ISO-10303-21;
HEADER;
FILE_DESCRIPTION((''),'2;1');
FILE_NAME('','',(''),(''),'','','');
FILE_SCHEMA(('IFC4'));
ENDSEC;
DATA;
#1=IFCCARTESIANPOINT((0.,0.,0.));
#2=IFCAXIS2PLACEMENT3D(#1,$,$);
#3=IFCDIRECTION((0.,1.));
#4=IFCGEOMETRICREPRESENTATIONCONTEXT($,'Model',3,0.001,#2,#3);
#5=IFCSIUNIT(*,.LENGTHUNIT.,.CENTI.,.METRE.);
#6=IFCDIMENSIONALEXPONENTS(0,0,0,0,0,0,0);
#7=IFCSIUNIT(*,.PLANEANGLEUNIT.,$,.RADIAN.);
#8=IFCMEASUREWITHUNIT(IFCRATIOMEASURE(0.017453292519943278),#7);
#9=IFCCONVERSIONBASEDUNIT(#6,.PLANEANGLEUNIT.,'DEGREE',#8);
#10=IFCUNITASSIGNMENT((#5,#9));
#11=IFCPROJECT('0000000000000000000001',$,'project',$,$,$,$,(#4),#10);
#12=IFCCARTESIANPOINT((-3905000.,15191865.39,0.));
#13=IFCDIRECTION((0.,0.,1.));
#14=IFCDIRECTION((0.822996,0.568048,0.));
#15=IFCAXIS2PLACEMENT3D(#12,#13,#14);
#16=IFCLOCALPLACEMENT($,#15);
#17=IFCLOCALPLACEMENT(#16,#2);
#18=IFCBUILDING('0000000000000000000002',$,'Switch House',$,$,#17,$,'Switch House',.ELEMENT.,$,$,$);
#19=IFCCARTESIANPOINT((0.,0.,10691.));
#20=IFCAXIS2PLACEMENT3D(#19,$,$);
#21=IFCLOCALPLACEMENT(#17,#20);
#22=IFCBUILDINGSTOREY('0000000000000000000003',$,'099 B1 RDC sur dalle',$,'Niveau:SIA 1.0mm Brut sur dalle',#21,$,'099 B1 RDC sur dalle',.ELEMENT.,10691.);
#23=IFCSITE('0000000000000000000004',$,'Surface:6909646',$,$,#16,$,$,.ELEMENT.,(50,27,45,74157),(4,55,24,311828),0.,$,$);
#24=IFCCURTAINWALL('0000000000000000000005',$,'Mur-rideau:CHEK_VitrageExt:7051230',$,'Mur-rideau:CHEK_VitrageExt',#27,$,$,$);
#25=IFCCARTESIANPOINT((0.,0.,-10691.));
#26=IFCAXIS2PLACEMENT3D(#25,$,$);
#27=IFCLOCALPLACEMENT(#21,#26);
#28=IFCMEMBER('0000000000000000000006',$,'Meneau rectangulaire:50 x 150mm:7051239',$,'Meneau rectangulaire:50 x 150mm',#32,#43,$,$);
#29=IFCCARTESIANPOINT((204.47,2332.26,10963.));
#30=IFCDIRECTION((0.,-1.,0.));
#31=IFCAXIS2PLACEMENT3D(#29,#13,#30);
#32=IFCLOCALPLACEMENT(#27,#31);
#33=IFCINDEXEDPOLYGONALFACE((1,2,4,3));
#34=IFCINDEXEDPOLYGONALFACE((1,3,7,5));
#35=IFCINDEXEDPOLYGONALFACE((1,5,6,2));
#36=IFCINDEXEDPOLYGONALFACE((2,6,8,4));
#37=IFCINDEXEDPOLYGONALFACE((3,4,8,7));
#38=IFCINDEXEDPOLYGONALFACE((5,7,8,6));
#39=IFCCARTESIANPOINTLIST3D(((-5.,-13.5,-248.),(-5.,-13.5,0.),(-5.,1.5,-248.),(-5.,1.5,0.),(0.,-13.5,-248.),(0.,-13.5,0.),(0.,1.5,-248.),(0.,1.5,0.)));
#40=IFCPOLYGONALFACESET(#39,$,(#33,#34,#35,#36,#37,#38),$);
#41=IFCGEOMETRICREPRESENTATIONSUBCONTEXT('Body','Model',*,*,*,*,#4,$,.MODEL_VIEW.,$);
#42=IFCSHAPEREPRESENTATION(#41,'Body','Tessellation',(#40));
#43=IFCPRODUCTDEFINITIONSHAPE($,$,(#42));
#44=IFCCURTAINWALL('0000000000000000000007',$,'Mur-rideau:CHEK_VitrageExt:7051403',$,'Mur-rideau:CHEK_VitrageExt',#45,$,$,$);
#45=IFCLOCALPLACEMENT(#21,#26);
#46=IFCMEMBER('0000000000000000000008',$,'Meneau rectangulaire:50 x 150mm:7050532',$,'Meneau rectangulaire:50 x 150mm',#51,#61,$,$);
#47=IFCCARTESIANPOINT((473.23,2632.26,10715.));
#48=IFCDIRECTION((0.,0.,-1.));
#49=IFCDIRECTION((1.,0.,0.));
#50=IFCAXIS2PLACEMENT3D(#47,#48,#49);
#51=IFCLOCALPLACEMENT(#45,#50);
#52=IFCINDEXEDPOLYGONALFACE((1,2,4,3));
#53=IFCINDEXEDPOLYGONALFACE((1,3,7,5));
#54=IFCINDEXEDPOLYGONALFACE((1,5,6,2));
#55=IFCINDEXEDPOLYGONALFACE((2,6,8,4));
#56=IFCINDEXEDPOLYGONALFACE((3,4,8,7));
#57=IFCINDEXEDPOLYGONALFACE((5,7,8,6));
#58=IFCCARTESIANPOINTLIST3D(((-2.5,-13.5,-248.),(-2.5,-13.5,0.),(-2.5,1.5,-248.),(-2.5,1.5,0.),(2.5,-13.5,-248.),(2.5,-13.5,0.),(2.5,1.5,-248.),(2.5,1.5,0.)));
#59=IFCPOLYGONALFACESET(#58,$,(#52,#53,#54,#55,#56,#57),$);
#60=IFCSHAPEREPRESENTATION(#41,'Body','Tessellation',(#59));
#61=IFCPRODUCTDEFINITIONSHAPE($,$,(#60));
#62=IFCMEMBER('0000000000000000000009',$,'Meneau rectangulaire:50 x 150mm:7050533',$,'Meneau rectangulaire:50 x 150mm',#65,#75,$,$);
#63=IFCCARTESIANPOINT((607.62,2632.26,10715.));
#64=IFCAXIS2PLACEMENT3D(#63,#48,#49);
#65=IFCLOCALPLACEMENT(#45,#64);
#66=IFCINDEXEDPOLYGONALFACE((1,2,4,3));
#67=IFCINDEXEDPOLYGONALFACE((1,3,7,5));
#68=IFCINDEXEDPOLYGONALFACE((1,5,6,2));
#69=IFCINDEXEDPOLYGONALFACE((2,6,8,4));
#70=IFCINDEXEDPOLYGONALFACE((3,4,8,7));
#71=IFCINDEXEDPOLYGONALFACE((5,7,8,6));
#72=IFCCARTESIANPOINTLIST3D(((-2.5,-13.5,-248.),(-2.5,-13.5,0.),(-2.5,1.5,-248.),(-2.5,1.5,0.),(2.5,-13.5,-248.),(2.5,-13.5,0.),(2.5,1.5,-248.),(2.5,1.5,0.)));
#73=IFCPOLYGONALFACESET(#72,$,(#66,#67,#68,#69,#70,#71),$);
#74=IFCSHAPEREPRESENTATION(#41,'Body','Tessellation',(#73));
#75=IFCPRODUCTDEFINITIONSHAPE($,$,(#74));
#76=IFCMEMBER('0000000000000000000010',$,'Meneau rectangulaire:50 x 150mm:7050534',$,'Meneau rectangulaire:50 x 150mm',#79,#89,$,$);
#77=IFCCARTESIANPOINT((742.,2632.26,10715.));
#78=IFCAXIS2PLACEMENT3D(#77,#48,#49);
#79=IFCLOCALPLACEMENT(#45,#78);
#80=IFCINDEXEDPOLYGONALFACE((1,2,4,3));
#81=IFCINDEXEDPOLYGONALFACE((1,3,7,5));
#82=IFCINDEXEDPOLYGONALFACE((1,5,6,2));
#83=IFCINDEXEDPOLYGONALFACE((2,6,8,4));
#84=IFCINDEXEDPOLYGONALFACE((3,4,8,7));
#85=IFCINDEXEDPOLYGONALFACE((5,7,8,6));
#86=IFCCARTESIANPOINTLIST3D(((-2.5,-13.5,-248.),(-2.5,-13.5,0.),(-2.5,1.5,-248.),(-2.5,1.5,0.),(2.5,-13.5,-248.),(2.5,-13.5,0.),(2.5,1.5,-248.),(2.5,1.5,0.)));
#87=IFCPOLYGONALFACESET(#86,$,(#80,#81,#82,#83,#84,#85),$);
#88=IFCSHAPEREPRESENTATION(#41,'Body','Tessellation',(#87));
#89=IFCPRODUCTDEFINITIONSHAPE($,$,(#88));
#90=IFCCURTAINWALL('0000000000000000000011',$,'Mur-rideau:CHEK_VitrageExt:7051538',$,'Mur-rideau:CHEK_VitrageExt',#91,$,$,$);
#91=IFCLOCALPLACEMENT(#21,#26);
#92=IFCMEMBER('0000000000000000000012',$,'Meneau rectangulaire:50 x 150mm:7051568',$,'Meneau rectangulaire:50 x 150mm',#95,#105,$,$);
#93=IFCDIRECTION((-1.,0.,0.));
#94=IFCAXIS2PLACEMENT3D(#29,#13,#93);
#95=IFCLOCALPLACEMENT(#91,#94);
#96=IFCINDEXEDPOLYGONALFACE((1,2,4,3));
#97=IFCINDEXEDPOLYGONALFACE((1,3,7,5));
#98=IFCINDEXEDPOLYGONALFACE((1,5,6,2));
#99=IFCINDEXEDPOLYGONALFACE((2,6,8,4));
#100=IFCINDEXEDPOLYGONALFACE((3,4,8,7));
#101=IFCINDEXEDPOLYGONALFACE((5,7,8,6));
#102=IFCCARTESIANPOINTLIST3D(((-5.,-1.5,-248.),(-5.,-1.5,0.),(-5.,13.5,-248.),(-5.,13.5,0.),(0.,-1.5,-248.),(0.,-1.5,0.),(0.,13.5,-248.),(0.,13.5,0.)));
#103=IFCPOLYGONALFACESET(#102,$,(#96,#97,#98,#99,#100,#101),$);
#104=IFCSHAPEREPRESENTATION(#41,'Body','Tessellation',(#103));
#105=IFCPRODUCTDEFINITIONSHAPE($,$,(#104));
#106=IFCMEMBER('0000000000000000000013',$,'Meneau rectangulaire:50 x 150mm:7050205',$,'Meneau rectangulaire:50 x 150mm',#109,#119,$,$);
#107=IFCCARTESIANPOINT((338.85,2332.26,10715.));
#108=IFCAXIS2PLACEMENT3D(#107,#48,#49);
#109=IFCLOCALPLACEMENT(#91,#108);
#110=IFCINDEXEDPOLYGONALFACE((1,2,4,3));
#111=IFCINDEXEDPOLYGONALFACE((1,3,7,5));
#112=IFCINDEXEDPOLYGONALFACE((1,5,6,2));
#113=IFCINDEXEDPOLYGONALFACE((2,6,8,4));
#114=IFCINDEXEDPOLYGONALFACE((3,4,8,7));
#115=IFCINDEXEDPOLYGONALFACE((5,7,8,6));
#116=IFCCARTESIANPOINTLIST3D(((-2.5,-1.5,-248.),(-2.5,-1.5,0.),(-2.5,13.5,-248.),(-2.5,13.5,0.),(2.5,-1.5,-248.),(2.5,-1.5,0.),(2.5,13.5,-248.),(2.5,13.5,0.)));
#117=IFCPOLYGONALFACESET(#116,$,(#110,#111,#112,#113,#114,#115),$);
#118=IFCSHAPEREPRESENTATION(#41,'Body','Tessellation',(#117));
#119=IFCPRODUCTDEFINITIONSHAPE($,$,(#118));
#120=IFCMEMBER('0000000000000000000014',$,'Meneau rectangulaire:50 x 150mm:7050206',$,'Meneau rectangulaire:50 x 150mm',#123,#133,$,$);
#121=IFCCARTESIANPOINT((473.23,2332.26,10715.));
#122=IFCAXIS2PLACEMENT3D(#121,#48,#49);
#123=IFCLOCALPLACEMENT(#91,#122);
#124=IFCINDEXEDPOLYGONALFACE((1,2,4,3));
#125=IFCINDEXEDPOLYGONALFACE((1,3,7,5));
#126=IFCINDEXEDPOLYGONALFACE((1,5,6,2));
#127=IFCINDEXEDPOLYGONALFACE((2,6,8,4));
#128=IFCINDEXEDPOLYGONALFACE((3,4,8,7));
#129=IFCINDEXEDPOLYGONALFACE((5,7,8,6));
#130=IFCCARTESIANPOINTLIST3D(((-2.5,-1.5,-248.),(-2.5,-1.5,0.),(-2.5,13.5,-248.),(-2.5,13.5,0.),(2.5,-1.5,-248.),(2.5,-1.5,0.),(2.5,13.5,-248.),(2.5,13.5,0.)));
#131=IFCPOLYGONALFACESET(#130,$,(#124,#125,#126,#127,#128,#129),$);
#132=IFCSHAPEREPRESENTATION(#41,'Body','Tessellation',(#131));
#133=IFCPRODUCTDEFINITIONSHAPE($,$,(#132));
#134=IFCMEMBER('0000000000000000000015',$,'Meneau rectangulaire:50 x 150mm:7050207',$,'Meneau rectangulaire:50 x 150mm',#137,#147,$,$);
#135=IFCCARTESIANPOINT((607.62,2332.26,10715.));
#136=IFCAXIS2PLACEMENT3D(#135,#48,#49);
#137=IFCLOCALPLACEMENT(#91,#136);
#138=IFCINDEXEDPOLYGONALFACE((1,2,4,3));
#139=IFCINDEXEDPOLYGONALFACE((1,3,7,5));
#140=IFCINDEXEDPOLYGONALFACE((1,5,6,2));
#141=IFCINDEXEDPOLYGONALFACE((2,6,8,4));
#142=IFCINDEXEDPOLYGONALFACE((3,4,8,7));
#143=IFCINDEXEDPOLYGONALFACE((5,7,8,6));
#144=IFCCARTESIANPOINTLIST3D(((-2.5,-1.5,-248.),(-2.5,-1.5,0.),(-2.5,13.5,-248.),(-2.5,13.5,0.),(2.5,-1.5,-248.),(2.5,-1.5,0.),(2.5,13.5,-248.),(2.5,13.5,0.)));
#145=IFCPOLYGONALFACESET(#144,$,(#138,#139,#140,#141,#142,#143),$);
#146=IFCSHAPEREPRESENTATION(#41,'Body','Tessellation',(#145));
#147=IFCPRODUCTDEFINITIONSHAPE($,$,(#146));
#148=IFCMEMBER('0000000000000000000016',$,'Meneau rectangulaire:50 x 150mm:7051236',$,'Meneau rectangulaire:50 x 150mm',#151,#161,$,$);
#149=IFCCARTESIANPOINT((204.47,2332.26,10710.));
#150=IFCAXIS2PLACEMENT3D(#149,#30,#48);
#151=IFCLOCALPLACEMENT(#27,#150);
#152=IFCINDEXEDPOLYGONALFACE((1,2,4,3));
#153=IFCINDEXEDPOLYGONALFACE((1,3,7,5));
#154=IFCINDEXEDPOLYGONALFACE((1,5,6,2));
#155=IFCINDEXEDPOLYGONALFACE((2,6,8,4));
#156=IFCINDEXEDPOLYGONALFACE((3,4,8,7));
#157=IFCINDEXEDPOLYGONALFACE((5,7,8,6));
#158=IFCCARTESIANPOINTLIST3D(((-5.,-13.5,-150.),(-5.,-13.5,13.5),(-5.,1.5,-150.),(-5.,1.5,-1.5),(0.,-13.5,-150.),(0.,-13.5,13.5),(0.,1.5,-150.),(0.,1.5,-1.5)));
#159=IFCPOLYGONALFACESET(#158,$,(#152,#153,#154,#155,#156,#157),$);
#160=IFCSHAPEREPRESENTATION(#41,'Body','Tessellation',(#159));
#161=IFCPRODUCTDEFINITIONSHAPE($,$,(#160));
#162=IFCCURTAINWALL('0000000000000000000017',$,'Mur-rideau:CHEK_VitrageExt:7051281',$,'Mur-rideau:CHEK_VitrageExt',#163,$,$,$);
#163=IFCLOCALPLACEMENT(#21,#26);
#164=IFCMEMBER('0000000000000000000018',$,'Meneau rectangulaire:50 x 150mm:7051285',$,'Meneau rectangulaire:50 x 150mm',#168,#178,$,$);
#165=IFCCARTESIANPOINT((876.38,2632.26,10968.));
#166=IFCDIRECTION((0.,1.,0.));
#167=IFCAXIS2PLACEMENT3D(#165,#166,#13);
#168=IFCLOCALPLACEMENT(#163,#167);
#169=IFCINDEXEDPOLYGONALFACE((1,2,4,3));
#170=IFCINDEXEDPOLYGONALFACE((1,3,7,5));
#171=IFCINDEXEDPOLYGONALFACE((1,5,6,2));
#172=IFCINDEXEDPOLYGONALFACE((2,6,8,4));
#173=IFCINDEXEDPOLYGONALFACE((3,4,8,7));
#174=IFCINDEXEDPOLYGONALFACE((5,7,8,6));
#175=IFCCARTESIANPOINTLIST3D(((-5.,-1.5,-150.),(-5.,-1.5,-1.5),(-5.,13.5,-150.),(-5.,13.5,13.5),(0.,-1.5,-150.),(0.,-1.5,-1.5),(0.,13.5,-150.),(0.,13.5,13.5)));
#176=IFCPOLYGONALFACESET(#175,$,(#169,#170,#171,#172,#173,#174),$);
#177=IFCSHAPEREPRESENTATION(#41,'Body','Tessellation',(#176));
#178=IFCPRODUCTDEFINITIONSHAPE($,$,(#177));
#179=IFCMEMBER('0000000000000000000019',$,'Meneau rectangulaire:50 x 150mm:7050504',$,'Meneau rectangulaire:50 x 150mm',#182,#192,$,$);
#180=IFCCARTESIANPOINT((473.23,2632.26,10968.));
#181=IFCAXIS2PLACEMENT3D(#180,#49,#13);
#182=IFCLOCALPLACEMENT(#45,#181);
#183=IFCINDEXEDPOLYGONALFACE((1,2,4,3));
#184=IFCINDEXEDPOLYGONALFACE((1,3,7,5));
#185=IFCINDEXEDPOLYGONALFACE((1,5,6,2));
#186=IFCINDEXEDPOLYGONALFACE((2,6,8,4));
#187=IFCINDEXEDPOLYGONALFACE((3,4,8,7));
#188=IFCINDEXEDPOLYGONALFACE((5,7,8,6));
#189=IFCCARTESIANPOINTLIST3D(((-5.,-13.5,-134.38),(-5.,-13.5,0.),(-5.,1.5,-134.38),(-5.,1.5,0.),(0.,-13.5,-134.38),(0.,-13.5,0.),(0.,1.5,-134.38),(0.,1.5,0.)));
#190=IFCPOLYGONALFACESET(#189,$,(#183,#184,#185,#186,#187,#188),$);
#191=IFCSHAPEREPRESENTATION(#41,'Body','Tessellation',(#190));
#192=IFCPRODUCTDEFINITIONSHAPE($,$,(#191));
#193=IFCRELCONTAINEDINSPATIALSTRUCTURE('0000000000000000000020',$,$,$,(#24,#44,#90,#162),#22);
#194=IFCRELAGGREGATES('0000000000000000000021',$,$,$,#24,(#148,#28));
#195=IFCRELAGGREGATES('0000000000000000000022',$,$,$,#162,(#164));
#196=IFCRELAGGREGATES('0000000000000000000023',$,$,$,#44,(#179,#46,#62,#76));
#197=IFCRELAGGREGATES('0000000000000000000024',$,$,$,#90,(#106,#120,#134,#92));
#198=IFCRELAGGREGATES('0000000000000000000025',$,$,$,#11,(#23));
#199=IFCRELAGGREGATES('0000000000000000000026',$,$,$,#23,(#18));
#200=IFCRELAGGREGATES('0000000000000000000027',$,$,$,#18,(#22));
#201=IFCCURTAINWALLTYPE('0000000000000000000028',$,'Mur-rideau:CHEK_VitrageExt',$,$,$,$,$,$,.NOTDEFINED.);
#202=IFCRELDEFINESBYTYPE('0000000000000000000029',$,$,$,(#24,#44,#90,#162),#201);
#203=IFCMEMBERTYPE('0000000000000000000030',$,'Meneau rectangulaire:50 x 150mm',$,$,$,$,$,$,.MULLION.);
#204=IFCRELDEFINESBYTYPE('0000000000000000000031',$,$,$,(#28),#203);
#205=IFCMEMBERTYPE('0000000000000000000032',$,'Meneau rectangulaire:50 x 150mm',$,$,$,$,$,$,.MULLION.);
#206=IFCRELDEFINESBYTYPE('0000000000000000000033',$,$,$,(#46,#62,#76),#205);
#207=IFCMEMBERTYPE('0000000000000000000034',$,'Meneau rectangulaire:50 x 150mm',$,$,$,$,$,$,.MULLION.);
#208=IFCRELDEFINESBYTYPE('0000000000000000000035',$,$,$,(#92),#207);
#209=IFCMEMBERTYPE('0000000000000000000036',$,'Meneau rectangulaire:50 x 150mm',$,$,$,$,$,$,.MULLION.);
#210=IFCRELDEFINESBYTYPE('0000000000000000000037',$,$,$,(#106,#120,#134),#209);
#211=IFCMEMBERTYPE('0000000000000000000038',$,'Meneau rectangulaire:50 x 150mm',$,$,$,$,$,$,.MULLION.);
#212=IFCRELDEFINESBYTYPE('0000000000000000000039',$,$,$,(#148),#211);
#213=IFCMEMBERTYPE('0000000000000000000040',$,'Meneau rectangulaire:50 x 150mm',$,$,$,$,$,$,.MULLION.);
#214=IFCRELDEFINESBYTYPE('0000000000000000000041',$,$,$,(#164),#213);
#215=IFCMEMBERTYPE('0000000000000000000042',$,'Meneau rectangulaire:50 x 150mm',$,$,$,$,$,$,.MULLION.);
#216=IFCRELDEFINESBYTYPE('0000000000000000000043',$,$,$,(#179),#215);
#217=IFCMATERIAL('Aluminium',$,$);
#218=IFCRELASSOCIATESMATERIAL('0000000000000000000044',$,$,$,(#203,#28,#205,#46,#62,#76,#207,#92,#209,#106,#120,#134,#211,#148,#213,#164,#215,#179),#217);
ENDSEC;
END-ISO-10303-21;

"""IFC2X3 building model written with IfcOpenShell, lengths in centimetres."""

from ifc_helpers import new_model, entity, si_unit, converted_unit, direction, frame, origin, origin_2d_with_axis, place, context, subcontext, project, spatial, rectangle, extrude, clip, halfspace, source, transform, mapped, material, type_object, type_shapes, element, aggregate, save


model = new_model("IFC2X3")

# Units and contexts
model_context = context("Model", 3, precision=0.001, world=origin(), true_north=direction((0.0, 1.0)))
body_context = subcontext(model_context, "Body", "Model", "MODEL_VIEW")
ifc_project = project(units=[si_unit("LENGTHUNIT", "METRE", prefix="CENTI"), converted_unit("PLANEANGLEUNIT", "DEGREE", entity("IfcRatioMeasure", 0.017453292519943278), si_unit("PLANEANGLEUNIT", "RADIAN"), dimensions=[0, 0, 0, 0, 0, 0, 0])], contexts=[model_context])

# Site, building, storey
site_placement = place(None, frame((-3905000.0, 15191865.39, 0.0), z_axis=(0.0, 0.0, 1.0), x_axis=(0.822996, 0.568048, 0.0)))
site = spatial("IfcSite", under=ifc_project, at=site_placement, Name="Surface:6909646", CompositionType="ELEMENT", RefLatitude=(50, 27, 45, 74157), RefLongitude=(4, 55, 24, 311828), RefElevation=0.0)
building_placement = place(site_placement, origin())
building = spatial("IfcBuilding", under=site, at=building_placement, Name="Switch House", LongName="Switch House", CompositionType="ELEMENT")
storey_placement = place(building_placement, frame((0.0, 0.0, 10691.0)))
storey = spatial("IfcBuildingStorey", under=building, at=storey_placement, Name="099 B1 RDC sur dalle", ObjectType="Niveau:SIA 1.0mm Brut sur dalle", LongName="099 B1 RDC sur dalle", CompositionType="ELEMENT", Elevation=10691.0)

# Curtain wall, member
curtain_wall_type = type_object("IfcCurtainWallType", Name="Mur-rideau:CHEK_VitrageExt", PredefinedType="NOTDEFINED")
curtain_wall_1_placement = place(storey_placement, frame((0.0, 0.0, -10691.0)))
curtain_wall_1 = element("IfcCurtainWall", 1, at=curtain_wall_1_placement, inside=storey, type_object=curtain_wall_type, Name="Mur-rideau:CHEK_VitrageExt:7051230", ObjectType="Mur-rideau:CHEK_VitrageExt")
ifc_material_1 = material(Name="Aluminium")
member_type_1 = type_object("IfcMemberType", Name="Meneau rectangulaire:50 x 150mm", PredefinedType="MULLION", material=ifc_material_1)
shared_shape_1 = source(origin(), body_context, "Body", "SweptSolid", [
    extrude(rectangle(XDim=15.0, YDim=5.0, at=origin_2d_with_axis()), frame((-2.5, -6.0, -248.0), z_axis=(0.0, 0.0, 1.0), x_axis=(0.0, -1.0, 0.0)), (0.0, 0.0, 1.0), 248.0),
])
type_shapes(member_type_1, [shared_shape_1])
member_1_placement = place(curtain_wall_1_placement, frame((204.47, 2332.26, 10963.0), z_axis=(0.0, 0.0, 1.0), x_axis=(0.0, -1.0, 0.0)))
member_1 = element("IfcMember", 2, at=member_1_placement, type_object=member_type_1, material=ifc_material_1, Name="Meneau rectangulaire:50 x 150mm:7051239", ObjectType="Meneau rectangulaire:50 x 150mm", context=body_context, shape_type="MappedRepresentation", body=[
    mapped(shared_shape_1, transform((0.0, 0.0, 0.0), scale=1.0)),
])

# Curtain walls, members
curtain_wall_2_placement = place(storey_placement, frame((0.0, 0.0, -10691.0)))
curtain_wall_2 = element("IfcCurtainWall", 3, at=curtain_wall_2_placement, inside=storey, type_object=curtain_wall_type, Name="Mur-rideau:CHEK_VitrageExt:7051403", ObjectType="Mur-rideau:CHEK_VitrageExt")
member_type_2 = type_object("IfcMemberType", Name="Meneau rectangulaire:50 x 150mm", PredefinedType="MULLION", material=ifc_material_1)
shared_shape_2 = source(origin(), body_context, "Body", "SweptSolid", [
    extrude(rectangle(XDim=15.0, YDim=5.0, at=origin_2d_with_axis()), frame((0.0, -6.0, -248.0), z_axis=(0.0, 0.0, 1.0), x_axis=(0.0, -1.0, 0.0)), (0.0, 0.0, 1.0), 248.0),
])
type_shapes(member_type_2, [shared_shape_2])
member_2_placement = place(curtain_wall_2_placement, frame((473.23, 2632.26, 10715.0), z_axis=(0.0, 0.0, -1.0), x_axis=(1.0, 0.0, 0.0)))
member_2 = element("IfcMember", 4, at=member_2_placement, type_object=member_type_2, material=ifc_material_1, Name="Meneau rectangulaire:50 x 150mm:7050532", ObjectType="Meneau rectangulaire:50 x 150mm", context=body_context, shape_type="MappedRepresentation", body=[
    mapped(shared_shape_2, transform((0.0, 0.0, 0.0), scale=1.0)),
])
member_3_placement = place(curtain_wall_2_placement, frame((607.62, 2632.26, 10715.0), z_axis=(0.0, 0.0, -1.0), x_axis=(1.0, 0.0, 0.0)))
member_3 = element("IfcMember", 5, at=member_3_placement, type_object=member_type_2, material=ifc_material_1, Name="Meneau rectangulaire:50 x 150mm:7050533", ObjectType="Meneau rectangulaire:50 x 150mm", context=body_context, shape_type="MappedRepresentation", body=[
    mapped(shared_shape_2, transform((0.0, 0.0, 0.0), scale=1.0)),
])
member_4_placement = place(curtain_wall_2_placement, frame((742.0, 2632.26, 10715.0), z_axis=(0.0, 0.0, -1.0), x_axis=(1.0, 0.0, 0.0)))
member_4 = element("IfcMember", 6, at=member_4_placement, type_object=member_type_2, material=ifc_material_1, Name="Meneau rectangulaire:50 x 150mm:7050534", ObjectType="Meneau rectangulaire:50 x 150mm", context=body_context, shape_type="MappedRepresentation", body=[
    mapped(shared_shape_2, transform((0.0, 0.0, 0.0), scale=1.0)),
])
curtain_wall_3_placement = place(storey_placement, frame((0.0, 0.0, -10691.0)))
curtain_wall_3 = element("IfcCurtainWall", 7, at=curtain_wall_3_placement, inside=storey, type_object=curtain_wall_type, Name="Mur-rideau:CHEK_VitrageExt:7051538", ObjectType="Mur-rideau:CHEK_VitrageExt")
member_type_3 = type_object("IfcMemberType", Name="Meneau rectangulaire:50 x 150mm", PredefinedType="MULLION", material=ifc_material_1)
shared_shape_3 = source(origin(), body_context, "Body", "SweptSolid", [
    extrude(rectangle(XDim=15.0, YDim=5.0, at=origin_2d_with_axis()), frame((-2.5, 6.0, -248.0), z_axis=(0.0, 0.0, 1.0), x_axis=(0.0, -1.0, 0.0)), (0.0, 0.0, 1.0), 248.0),
])
type_shapes(member_type_3, [shared_shape_3])
member_5_placement = place(curtain_wall_3_placement, frame((204.47, 2332.26, 10963.0), z_axis=(0.0, 0.0, 1.0), x_axis=(-1.0, 0.0, 0.0)))
member_5 = element("IfcMember", 8, at=member_5_placement, type_object=member_type_3, material=ifc_material_1, Name="Meneau rectangulaire:50 x 150mm:7051568", ObjectType="Meneau rectangulaire:50 x 150mm", context=body_context, shape_type="MappedRepresentation", body=[
    mapped(shared_shape_3, transform((0.0, 0.0, 0.0), scale=1.0)),
])
member_type_4 = type_object("IfcMemberType", Name="Meneau rectangulaire:50 x 150mm", PredefinedType="MULLION", material=ifc_material_1)
shared_shape_4 = source(origin(), body_context, "Body", "SweptSolid", [
    extrude(rectangle(XDim=15.0, YDim=5.0, at=origin_2d_with_axis()), frame((0.0, 6.0, -248.0), z_axis=(0.0, 0.0, 1.0), x_axis=(0.0, -1.0, 0.0)), (0.0, 0.0, 1.0), 248.0),
])
type_shapes(member_type_4, [shared_shape_4])
member_6_placement = place(curtain_wall_3_placement, frame((338.85, 2332.26, 10715.0), z_axis=(0.0, 0.0, -1.0), x_axis=(1.0, 0.0, 0.0)))
member_6 = element("IfcMember", 9, at=member_6_placement, type_object=member_type_4, material=ifc_material_1, Name="Meneau rectangulaire:50 x 150mm:7050205", ObjectType="Meneau rectangulaire:50 x 150mm", context=body_context, shape_type="MappedRepresentation", body=[
    mapped(shared_shape_4, transform((0.0, 0.0, 0.0), scale=1.0)),
])
member_7_placement = place(curtain_wall_3_placement, frame((473.23, 2332.26, 10715.0), z_axis=(0.0, 0.0, -1.0), x_axis=(1.0, 0.0, 0.0)))
member_7 = element("IfcMember", 10, at=member_7_placement, type_object=member_type_4, material=ifc_material_1, Name="Meneau rectangulaire:50 x 150mm:7050206", ObjectType="Meneau rectangulaire:50 x 150mm", context=body_context, shape_type="MappedRepresentation", body=[
    mapped(shared_shape_4, transform((0.0, 0.0, 0.0), scale=1.0)),
])
member_8_placement = place(curtain_wall_3_placement, frame((607.62, 2332.26, 10715.0), z_axis=(0.0, 0.0, -1.0), x_axis=(1.0, 0.0, 0.0)))
member_8 = element("IfcMember", 11, at=member_8_placement, type_object=member_type_4, material=ifc_material_1, Name="Meneau rectangulaire:50 x 150mm:7050207", ObjectType="Meneau rectangulaire:50 x 150mm", context=body_context, shape_type="MappedRepresentation", body=[
    mapped(shared_shape_4, transform((0.0, 0.0, 0.0), scale=1.0)),
])

# Member
member_type_5 = type_object("IfcMemberType", Name="Meneau rectangulaire:50 x 150mm", PredefinedType="MULLION", material=ifc_material_1)
shared_shape_5 = source(origin(), body_context, "Body", "SweptSolid", [
    clip(extrude(rectangle(XDim=15.0, YDim=5.0, at=origin_2d_with_axis()), frame((-2.5, -6.0, -150.0), z_axis=(0.0, 0.0, 1.0), x_axis=(0.0, -1.0, 0.0)), (0.0, 0.0, 1.0), 163.5), halfspace(frame((-30.48, 0.0, 0.0), z_axis=(0.0, 0.707107, 0.707107), x_axis=(0.0, 0.707107, -0.707107)), False)),
])
type_shapes(member_type_5, [shared_shape_5])
member_9_placement = place(curtain_wall_1_placement, frame((204.47, 2332.26, 10710.0), z_axis=(0.0, -1.0, 0.0), x_axis=(0.0, 0.0, -1.0)))
member_9 = element("IfcMember", 12, at=member_9_placement, type_object=member_type_5, material=ifc_material_1, Name="Meneau rectangulaire:50 x 150mm:7051236", ObjectType="Meneau rectangulaire:50 x 150mm", context=body_context, shape_type="MappedRepresentation", body=[
    mapped(shared_shape_5, transform((0.0, 0.0, 0.0), scale=1.0)),
])
aggregate(curtain_wall_1, [member_9, member_1])

# Curtain wall, member
curtain_wall_4_placement = place(storey_placement, frame((0.0, 0.0, -10691.0)))
curtain_wall_4 = element("IfcCurtainWall", 13, at=curtain_wall_4_placement, inside=storey, type_object=curtain_wall_type, Name="Mur-rideau:CHEK_VitrageExt:7051281", ObjectType="Mur-rideau:CHEK_VitrageExt")
member_type_6 = type_object("IfcMemberType", Name="Meneau rectangulaire:50 x 150mm", PredefinedType="MULLION", material=ifc_material_1)
shared_shape_6 = source(origin(), body_context, "Body", "SweptSolid", [
    clip(extrude(rectangle(XDim=15.0, YDim=5.0, at=origin_2d_with_axis()), frame((-2.5, 6.0, -150.0), z_axis=(0.0, 0.0, 1.0), x_axis=(0.0, -1.0, 0.0)), (0.0, 0.0, 1.0), 163.5), halfspace(frame((30.48, 0.0, 0.0), z_axis=(0.0, -0.707107, 0.707107), x_axis=(0.0, -0.707107, -0.707107)), False)),
])
type_shapes(member_type_6, [shared_shape_6])
member_10_placement = place(curtain_wall_4_placement, frame((876.38, 2632.26, 10968.0), z_axis=(0.0, 1.0, 0.0), x_axis=(0.0, 0.0, 1.0)))
member_10 = element("IfcMember", 14, at=member_10_placement, type_object=member_type_6, material=ifc_material_1, Name="Meneau rectangulaire:50 x 150mm:7051285", ObjectType="Meneau rectangulaire:50 x 150mm", context=body_context, shape_type="MappedRepresentation", body=[
    mapped(shared_shape_6, transform((0.0, 0.0, 0.0), scale=1.0)),
])
aggregate(curtain_wall_4, [member_10])

# Member
member_type_7 = type_object("IfcMemberType", Name="Meneau rectangulaire:50 x 150mm", PredefinedType="MULLION", material=ifc_material_1)
shared_shape_7 = source(origin(), body_context, "Body", "SweptSolid", [
    extrude(rectangle(XDim=15.0, YDim=5.0, at=origin_2d_with_axis()), frame((-2.5, -6.0, -134.38), z_axis=(0.0, 0.0, 1.0), x_axis=(0.0, -1.0, 0.0)), (0.0, 0.0, 1.0), 134.38),
])
type_shapes(member_type_7, [shared_shape_7])
member_11_placement = place(curtain_wall_2_placement, frame((473.23, 2632.26, 10968.0), z_axis=(1.0, 0.0, 0.0), x_axis=(0.0, 0.0, 1.0)))
member_11 = element("IfcMember", 15, at=member_11_placement, type_object=member_type_7, material=ifc_material_1, Name="Meneau rectangulaire:50 x 150mm:7050504", ObjectType="Meneau rectangulaire:50 x 150mm", context=body_context, shape_type="MappedRepresentation", body=[
    mapped(shared_shape_7, transform((0.0, 0.0, 0.0), scale=1.0)),
])

aggregate(curtain_wall_2, [member_11, member_2, member_3, member_4])
aggregate(curtain_wall_3, [member_6, member_7, member_8, member_5])

save(model, "model.ifc")
